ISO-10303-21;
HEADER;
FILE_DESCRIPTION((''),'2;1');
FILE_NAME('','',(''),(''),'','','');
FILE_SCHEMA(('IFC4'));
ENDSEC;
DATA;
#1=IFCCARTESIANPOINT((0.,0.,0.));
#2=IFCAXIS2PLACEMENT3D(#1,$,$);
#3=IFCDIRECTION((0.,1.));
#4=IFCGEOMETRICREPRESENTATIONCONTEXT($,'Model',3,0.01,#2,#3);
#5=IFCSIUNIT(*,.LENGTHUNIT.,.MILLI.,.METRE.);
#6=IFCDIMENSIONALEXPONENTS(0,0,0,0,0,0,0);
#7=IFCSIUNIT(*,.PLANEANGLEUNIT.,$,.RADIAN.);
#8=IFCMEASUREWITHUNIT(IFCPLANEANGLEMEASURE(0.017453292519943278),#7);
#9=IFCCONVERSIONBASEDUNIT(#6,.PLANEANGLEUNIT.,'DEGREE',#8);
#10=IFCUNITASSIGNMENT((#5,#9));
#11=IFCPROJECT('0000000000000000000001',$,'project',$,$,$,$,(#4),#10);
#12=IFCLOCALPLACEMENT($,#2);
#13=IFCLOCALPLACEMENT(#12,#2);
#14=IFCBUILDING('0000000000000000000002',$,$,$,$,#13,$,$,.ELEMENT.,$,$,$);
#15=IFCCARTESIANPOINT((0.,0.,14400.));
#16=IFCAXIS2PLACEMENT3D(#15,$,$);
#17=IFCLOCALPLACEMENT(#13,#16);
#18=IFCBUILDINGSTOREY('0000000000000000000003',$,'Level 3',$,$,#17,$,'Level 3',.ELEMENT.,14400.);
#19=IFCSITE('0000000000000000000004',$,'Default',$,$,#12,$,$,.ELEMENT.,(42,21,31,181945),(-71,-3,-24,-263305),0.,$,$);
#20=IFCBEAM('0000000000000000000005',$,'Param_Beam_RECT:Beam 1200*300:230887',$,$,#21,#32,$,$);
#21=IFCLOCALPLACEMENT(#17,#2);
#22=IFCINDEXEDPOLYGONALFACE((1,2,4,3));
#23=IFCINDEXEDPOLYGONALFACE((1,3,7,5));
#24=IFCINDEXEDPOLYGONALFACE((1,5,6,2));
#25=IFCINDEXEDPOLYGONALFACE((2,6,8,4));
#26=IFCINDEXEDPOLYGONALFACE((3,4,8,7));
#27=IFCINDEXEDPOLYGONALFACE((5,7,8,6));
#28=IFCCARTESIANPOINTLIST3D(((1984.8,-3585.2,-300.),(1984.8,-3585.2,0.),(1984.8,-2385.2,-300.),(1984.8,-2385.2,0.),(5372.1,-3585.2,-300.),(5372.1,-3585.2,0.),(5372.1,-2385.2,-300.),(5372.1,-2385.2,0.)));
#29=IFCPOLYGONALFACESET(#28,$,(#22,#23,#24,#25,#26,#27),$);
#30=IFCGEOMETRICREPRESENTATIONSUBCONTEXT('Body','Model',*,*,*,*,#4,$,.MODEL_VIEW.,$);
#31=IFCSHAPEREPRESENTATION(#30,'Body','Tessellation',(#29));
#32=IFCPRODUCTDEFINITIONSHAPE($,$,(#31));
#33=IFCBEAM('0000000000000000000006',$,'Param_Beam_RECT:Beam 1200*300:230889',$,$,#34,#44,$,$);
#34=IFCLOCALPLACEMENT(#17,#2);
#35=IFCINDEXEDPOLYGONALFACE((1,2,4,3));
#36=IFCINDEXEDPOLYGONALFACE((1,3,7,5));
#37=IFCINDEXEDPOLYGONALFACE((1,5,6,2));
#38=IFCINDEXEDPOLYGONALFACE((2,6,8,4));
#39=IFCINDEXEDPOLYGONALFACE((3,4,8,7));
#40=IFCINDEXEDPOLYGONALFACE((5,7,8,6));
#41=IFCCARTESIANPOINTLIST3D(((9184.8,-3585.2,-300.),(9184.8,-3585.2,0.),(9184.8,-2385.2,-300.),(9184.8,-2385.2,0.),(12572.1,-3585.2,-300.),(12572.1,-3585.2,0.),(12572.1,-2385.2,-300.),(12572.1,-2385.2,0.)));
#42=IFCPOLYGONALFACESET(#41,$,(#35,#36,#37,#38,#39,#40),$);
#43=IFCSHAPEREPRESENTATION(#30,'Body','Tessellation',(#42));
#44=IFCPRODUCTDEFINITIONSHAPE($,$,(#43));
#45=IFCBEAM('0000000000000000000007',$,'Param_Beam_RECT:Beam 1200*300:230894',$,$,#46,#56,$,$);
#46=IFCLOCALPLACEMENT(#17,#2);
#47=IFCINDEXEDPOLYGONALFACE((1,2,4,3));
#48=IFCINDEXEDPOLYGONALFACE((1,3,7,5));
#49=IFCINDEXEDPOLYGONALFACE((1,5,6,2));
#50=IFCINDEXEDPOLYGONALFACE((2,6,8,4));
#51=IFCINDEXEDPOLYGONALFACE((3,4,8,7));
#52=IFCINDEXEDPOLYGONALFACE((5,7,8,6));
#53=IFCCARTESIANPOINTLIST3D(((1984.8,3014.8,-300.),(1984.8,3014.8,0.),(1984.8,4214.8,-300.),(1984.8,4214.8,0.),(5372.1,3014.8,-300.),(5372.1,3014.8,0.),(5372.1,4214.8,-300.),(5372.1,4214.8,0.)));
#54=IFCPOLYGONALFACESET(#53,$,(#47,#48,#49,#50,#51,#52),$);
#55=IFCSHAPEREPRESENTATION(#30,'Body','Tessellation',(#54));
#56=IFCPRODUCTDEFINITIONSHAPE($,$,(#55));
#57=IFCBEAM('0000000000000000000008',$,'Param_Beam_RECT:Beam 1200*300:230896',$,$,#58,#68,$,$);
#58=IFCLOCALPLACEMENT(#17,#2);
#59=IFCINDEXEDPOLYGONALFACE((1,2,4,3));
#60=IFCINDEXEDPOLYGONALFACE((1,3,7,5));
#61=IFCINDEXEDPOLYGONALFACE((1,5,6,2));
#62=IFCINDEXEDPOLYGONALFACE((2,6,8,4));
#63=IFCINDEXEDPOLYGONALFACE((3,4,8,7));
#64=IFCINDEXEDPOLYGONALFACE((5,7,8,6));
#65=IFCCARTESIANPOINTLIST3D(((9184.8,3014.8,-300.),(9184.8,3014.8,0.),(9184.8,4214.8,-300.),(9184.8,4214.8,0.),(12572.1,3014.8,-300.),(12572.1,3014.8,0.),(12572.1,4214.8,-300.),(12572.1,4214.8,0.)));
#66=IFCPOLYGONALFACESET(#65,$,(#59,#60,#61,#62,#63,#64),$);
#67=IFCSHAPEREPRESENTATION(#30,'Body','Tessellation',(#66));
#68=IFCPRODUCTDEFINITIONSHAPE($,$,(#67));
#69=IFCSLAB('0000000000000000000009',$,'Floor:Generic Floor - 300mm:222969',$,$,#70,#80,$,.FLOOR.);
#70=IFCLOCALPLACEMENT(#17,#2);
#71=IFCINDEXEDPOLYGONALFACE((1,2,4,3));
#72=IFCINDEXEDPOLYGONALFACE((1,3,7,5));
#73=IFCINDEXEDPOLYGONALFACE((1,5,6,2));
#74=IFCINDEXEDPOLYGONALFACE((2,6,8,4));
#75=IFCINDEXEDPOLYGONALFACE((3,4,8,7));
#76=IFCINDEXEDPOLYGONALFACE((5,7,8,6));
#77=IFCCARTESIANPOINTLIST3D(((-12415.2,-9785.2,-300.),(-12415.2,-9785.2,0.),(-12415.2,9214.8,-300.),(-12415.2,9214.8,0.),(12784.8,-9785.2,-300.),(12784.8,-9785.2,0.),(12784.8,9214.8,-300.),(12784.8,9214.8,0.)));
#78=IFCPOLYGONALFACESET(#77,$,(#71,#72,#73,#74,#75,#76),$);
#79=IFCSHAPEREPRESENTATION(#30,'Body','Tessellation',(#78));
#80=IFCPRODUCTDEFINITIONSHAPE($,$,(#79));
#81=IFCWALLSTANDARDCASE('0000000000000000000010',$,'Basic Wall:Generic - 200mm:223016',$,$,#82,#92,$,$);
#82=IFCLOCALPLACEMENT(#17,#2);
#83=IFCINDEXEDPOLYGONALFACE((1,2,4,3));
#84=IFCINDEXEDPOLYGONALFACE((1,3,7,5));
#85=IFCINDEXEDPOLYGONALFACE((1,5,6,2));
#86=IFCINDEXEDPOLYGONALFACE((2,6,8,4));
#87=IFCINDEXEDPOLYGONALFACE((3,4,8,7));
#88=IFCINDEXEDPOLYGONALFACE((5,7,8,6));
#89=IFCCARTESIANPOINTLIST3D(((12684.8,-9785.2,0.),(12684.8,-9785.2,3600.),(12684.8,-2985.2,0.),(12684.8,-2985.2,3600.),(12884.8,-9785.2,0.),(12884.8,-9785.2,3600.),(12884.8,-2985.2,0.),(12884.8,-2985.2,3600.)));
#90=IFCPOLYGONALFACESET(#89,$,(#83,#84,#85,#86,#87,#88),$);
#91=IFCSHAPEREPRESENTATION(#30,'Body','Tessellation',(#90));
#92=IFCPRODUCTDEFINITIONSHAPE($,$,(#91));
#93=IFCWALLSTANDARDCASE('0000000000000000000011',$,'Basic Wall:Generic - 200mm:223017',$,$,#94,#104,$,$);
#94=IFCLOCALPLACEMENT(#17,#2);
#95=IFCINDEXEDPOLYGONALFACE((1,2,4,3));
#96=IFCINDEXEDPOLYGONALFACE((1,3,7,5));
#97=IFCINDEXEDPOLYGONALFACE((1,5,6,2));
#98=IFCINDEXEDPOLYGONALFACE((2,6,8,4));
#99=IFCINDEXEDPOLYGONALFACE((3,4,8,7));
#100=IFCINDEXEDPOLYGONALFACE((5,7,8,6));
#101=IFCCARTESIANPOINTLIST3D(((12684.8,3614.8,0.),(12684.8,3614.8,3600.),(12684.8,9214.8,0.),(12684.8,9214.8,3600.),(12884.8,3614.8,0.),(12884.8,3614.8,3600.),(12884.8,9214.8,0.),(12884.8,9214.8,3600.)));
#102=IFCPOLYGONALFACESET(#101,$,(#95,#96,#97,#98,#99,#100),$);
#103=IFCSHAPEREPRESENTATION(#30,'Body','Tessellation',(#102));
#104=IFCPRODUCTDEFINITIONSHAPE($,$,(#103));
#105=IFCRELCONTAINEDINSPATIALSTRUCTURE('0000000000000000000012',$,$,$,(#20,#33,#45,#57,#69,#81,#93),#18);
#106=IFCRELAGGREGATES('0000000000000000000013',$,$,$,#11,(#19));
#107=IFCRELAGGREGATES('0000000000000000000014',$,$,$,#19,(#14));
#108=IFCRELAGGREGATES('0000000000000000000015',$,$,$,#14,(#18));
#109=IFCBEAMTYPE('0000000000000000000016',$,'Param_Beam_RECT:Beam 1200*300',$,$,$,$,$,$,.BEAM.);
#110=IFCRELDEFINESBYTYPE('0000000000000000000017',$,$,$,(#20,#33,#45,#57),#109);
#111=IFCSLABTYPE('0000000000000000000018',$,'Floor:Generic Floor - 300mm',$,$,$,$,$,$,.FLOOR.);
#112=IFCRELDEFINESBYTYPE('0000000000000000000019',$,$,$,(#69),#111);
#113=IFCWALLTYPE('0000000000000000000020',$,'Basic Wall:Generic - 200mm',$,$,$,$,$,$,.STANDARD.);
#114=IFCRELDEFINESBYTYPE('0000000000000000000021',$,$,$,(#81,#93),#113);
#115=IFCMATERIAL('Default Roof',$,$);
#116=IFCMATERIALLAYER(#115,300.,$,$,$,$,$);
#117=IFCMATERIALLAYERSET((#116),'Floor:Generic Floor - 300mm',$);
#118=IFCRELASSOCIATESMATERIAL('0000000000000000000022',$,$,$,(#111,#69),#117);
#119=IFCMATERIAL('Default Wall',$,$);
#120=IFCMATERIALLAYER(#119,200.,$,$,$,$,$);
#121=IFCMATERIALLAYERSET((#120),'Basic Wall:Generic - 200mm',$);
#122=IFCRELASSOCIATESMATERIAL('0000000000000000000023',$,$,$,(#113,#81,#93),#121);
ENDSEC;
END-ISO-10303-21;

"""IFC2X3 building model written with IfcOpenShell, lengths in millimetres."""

from ifc_helpers import new_model, entity, si_unit, converted_unit, direction, frame, frame_2d, origin, origin_2d_with_axis, place, context, subcontext, project, spatial, rectangle, extrude, material, layer, layer_set, layer_usage, type_object, element, save


model = new_model("IFC2X3")

# Units and contexts
model_context = context("Model", 3, precision=0.01, world=origin(), true_north=direction((0.0, 1.0)))
body_context = subcontext(model_context, "Body", "Model", "MODEL_VIEW")
ifc_project = project(units=[si_unit("LENGTHUNIT", "METRE", prefix="MILLI"), converted_unit("PLANEANGLEUNIT", "DEGREE", entity("IfcPlaneAngleMeasure", 0.017453292519943278), si_unit("PLANEANGLEUNIT", "RADIAN"), dimensions=[0, 0, 0, 0, 0, 0, 0])], contexts=[model_context])

# Site, building, storey
site_placement = place(None, origin())
site = spatial("IfcSite", under=ifc_project, at=site_placement, Name="Default", CompositionType="ELEMENT", RefLatitude=(42, 21, 31, 181945), RefLongitude=(-71, -3, -24, -263305), RefElevation=0.0)
building_placement = place(site_placement, origin())
building = spatial("IfcBuilding", under=site, at=building_placement, CompositionType="ELEMENT")
storey_placement = place(building_placement, frame((0.0, 0.0, 14400.0)))
storey = spatial("IfcBuildingStorey", under=building, at=storey_placement, Name="Level 3", LongName="Level 3", CompositionType="ELEMENT", Elevation=14400.0)

# Beams
beam_type_1 = type_object("IfcBeamType", Name="Param_Beam_RECT:Beam 1200*300", PredefinedType="BEAM")
beam_1_placement = place(storey_placement, frame((1984.8, -2985.2, 0.0)))
element("IfcBeam", 1, at=beam_1_placement, inside=storey, type_object=beam_type_1, Name="Param_Beam_RECT:Beam 1200*300:230887", context=body_context, shape_type="SweptSolid", body=[
    extrude(rectangle(XDim=300.0, YDim=1200.0, at=frame_2d((0.0, 0.0), x_axis=(1.0, 0.0))), frame((0.0, 0.0, -150.0), z_axis=(1.0, 0.0, 0.0), x_axis=(0.0, 0.0, -1.0)), (0.0, 0.0, 1.0), 3387.3),
])
beam_2_placement = place(storey_placement, frame((9184.8, -2985.2, 0.0)))
element("IfcBeam", 2, at=beam_2_placement, inside=storey, type_object=beam_type_1, Name="Param_Beam_RECT:Beam 1200*300:230889", context=body_context, shape_type="SweptSolid", body=[
    extrude(rectangle(XDim=300.0, YDim=1200.0, at=frame_2d((0.0, 0.0), x_axis=(1.0, 0.0))), frame((0.0, 0.0, -150.0), z_axis=(1.0, 0.0, 0.0), x_axis=(0.0, 0.0, -1.0)), (0.0, 0.0, 1.0), 3387.3),
])
beam_3_placement = place(storey_placement, frame((1984.8, 3614.8, 0.0)))
element("IfcBeam", 3, at=beam_3_placement, inside=storey, type_object=beam_type_1, Name="Param_Beam_RECT:Beam 1200*300:230894", context=body_context, shape_type="SweptSolid", body=[
    extrude(rectangle(XDim=300.0, YDim=1200.0, at=frame_2d((0.0, 0.0), x_axis=(1.0, 0.0))), frame((0.0, 0.0, -150.0), z_axis=(1.0, 0.0, 0.0), x_axis=(0.0, 0.0, -1.0)), (0.0, 0.0, 1.0), 3387.3),
])
beam_4_placement = place(storey_placement, frame((9184.8, 3614.8, 0.0)))
element("IfcBeam", 4, at=beam_4_placement, inside=storey, type_object=beam_type_1, Name="Param_Beam_RECT:Beam 1200*300:230896", context=body_context, shape_type="SweptSolid", body=[
    extrude(rectangle(XDim=300.0, YDim=1200.0, at=frame_2d((0.0, 0.0), x_axis=(1.0, 0.0))), frame((0.0, 0.0, -150.0), z_axis=(1.0, 0.0, 0.0), x_axis=(0.0, 0.0, -1.0)), (0.0, 0.0, 1.0), 3387.3),
])

# Slab
ifc_material_1 = material(Name="Default Roof")
ifc_layer_1 = layer(ifc_material_1, 300.0)
ifc_layer_set_1 = layer_set([ifc_layer_1], Name="Floor:Generic Floor - 300mm")
ifc_layer_usage_1 = layer_usage(ifc_layer_set_1, "AXIS3", "POSITIVE", 0.0)
slab_type = type_object("IfcSlabType", Name="Floor:Generic Floor - 300mm", PredefinedType="FLOOR", material=ifc_layer_set_1)
slab_placement = place(storey_placement, origin())
element("IfcSlab", 5, at=slab_placement, inside=storey, type_object=slab_type, material=ifc_layer_usage_1, Name="Floor:Generic Floor - 300mm:222969", PredefinedType="FLOOR", context=body_context, shape_type="SweptSolid", body=[
    extrude(rectangle(XDim=19000.0, YDim=25200.0, at=origin_2d_with_axis()), frame((184.8, -285.2, 0.0), z_axis=(0.0, 0.0, -1.0), x_axis=(0.0, 1.0, 0.0)), (0.0, 0.0, 1.0), 300.0),
])

# Walls
ifc_material_2 = material(Name="Default Wall")
ifc_layer_2 = layer(ifc_material_2, 200.0)
ifc_layer_set_2 = layer_set([ifc_layer_2], Name="Basic Wall:Generic - 200mm")
ifc_layer_usage_2 = layer_usage(ifc_layer_set_2, "AXIS2", "NEGATIVE", 100.0)
wall_type = type_object("IfcWallType", Name="Basic Wall:Generic - 200mm", PredefinedType="STANDARD", material=ifc_layer_set_2)
wall_1_placement = place(storey_placement, frame((12784.8, -9785.2, 0.0), z_axis=(0.0, 0.0, 1.0), x_axis=(0.0, 1.0, 0.0)))
element("IfcWallStandardCase", 6, at=wall_1_placement, inside=storey, type_object=wall_type, material=ifc_layer_usage_2, Name="Basic Wall:Generic - 200mm:223016", context=body_context, shape_type="SweptSolid", body=[
    extrude(rectangle(XDim=6800.0, YDim=200.0, at=frame_2d((3400.0, 0.0), x_axis=(-1.0, 0.0))), origin(), (0.0, 0.0, 1.0), 3600.0),
])
ifc_layer_usage_3 = layer_usage(ifc_layer_set_2, "AXIS2", "NEGATIVE", 100.0)
wall_2_placement = place(storey_placement, frame((12784.8, 3614.8, 0.0), z_axis=(0.0, 0.0, 1.0), x_axis=(0.0, 1.0, 0.0)))
element("IfcWallStandardCase", 7, at=wall_2_placement, inside=storey, type_object=wall_type, material=ifc_layer_usage_3, Name="Basic Wall:Generic - 200mm:223017", context=body_context, shape_type="SweptSolid", body=[
    extrude(rectangle(XDim=5600.0, YDim=200.0, at=frame_2d((2800.0, 0.0), x_axis=(-1.0, 0.0))), origin(), (0.0, 0.0, 1.0), 3600.0),
])

save(model, "model.ifc")
